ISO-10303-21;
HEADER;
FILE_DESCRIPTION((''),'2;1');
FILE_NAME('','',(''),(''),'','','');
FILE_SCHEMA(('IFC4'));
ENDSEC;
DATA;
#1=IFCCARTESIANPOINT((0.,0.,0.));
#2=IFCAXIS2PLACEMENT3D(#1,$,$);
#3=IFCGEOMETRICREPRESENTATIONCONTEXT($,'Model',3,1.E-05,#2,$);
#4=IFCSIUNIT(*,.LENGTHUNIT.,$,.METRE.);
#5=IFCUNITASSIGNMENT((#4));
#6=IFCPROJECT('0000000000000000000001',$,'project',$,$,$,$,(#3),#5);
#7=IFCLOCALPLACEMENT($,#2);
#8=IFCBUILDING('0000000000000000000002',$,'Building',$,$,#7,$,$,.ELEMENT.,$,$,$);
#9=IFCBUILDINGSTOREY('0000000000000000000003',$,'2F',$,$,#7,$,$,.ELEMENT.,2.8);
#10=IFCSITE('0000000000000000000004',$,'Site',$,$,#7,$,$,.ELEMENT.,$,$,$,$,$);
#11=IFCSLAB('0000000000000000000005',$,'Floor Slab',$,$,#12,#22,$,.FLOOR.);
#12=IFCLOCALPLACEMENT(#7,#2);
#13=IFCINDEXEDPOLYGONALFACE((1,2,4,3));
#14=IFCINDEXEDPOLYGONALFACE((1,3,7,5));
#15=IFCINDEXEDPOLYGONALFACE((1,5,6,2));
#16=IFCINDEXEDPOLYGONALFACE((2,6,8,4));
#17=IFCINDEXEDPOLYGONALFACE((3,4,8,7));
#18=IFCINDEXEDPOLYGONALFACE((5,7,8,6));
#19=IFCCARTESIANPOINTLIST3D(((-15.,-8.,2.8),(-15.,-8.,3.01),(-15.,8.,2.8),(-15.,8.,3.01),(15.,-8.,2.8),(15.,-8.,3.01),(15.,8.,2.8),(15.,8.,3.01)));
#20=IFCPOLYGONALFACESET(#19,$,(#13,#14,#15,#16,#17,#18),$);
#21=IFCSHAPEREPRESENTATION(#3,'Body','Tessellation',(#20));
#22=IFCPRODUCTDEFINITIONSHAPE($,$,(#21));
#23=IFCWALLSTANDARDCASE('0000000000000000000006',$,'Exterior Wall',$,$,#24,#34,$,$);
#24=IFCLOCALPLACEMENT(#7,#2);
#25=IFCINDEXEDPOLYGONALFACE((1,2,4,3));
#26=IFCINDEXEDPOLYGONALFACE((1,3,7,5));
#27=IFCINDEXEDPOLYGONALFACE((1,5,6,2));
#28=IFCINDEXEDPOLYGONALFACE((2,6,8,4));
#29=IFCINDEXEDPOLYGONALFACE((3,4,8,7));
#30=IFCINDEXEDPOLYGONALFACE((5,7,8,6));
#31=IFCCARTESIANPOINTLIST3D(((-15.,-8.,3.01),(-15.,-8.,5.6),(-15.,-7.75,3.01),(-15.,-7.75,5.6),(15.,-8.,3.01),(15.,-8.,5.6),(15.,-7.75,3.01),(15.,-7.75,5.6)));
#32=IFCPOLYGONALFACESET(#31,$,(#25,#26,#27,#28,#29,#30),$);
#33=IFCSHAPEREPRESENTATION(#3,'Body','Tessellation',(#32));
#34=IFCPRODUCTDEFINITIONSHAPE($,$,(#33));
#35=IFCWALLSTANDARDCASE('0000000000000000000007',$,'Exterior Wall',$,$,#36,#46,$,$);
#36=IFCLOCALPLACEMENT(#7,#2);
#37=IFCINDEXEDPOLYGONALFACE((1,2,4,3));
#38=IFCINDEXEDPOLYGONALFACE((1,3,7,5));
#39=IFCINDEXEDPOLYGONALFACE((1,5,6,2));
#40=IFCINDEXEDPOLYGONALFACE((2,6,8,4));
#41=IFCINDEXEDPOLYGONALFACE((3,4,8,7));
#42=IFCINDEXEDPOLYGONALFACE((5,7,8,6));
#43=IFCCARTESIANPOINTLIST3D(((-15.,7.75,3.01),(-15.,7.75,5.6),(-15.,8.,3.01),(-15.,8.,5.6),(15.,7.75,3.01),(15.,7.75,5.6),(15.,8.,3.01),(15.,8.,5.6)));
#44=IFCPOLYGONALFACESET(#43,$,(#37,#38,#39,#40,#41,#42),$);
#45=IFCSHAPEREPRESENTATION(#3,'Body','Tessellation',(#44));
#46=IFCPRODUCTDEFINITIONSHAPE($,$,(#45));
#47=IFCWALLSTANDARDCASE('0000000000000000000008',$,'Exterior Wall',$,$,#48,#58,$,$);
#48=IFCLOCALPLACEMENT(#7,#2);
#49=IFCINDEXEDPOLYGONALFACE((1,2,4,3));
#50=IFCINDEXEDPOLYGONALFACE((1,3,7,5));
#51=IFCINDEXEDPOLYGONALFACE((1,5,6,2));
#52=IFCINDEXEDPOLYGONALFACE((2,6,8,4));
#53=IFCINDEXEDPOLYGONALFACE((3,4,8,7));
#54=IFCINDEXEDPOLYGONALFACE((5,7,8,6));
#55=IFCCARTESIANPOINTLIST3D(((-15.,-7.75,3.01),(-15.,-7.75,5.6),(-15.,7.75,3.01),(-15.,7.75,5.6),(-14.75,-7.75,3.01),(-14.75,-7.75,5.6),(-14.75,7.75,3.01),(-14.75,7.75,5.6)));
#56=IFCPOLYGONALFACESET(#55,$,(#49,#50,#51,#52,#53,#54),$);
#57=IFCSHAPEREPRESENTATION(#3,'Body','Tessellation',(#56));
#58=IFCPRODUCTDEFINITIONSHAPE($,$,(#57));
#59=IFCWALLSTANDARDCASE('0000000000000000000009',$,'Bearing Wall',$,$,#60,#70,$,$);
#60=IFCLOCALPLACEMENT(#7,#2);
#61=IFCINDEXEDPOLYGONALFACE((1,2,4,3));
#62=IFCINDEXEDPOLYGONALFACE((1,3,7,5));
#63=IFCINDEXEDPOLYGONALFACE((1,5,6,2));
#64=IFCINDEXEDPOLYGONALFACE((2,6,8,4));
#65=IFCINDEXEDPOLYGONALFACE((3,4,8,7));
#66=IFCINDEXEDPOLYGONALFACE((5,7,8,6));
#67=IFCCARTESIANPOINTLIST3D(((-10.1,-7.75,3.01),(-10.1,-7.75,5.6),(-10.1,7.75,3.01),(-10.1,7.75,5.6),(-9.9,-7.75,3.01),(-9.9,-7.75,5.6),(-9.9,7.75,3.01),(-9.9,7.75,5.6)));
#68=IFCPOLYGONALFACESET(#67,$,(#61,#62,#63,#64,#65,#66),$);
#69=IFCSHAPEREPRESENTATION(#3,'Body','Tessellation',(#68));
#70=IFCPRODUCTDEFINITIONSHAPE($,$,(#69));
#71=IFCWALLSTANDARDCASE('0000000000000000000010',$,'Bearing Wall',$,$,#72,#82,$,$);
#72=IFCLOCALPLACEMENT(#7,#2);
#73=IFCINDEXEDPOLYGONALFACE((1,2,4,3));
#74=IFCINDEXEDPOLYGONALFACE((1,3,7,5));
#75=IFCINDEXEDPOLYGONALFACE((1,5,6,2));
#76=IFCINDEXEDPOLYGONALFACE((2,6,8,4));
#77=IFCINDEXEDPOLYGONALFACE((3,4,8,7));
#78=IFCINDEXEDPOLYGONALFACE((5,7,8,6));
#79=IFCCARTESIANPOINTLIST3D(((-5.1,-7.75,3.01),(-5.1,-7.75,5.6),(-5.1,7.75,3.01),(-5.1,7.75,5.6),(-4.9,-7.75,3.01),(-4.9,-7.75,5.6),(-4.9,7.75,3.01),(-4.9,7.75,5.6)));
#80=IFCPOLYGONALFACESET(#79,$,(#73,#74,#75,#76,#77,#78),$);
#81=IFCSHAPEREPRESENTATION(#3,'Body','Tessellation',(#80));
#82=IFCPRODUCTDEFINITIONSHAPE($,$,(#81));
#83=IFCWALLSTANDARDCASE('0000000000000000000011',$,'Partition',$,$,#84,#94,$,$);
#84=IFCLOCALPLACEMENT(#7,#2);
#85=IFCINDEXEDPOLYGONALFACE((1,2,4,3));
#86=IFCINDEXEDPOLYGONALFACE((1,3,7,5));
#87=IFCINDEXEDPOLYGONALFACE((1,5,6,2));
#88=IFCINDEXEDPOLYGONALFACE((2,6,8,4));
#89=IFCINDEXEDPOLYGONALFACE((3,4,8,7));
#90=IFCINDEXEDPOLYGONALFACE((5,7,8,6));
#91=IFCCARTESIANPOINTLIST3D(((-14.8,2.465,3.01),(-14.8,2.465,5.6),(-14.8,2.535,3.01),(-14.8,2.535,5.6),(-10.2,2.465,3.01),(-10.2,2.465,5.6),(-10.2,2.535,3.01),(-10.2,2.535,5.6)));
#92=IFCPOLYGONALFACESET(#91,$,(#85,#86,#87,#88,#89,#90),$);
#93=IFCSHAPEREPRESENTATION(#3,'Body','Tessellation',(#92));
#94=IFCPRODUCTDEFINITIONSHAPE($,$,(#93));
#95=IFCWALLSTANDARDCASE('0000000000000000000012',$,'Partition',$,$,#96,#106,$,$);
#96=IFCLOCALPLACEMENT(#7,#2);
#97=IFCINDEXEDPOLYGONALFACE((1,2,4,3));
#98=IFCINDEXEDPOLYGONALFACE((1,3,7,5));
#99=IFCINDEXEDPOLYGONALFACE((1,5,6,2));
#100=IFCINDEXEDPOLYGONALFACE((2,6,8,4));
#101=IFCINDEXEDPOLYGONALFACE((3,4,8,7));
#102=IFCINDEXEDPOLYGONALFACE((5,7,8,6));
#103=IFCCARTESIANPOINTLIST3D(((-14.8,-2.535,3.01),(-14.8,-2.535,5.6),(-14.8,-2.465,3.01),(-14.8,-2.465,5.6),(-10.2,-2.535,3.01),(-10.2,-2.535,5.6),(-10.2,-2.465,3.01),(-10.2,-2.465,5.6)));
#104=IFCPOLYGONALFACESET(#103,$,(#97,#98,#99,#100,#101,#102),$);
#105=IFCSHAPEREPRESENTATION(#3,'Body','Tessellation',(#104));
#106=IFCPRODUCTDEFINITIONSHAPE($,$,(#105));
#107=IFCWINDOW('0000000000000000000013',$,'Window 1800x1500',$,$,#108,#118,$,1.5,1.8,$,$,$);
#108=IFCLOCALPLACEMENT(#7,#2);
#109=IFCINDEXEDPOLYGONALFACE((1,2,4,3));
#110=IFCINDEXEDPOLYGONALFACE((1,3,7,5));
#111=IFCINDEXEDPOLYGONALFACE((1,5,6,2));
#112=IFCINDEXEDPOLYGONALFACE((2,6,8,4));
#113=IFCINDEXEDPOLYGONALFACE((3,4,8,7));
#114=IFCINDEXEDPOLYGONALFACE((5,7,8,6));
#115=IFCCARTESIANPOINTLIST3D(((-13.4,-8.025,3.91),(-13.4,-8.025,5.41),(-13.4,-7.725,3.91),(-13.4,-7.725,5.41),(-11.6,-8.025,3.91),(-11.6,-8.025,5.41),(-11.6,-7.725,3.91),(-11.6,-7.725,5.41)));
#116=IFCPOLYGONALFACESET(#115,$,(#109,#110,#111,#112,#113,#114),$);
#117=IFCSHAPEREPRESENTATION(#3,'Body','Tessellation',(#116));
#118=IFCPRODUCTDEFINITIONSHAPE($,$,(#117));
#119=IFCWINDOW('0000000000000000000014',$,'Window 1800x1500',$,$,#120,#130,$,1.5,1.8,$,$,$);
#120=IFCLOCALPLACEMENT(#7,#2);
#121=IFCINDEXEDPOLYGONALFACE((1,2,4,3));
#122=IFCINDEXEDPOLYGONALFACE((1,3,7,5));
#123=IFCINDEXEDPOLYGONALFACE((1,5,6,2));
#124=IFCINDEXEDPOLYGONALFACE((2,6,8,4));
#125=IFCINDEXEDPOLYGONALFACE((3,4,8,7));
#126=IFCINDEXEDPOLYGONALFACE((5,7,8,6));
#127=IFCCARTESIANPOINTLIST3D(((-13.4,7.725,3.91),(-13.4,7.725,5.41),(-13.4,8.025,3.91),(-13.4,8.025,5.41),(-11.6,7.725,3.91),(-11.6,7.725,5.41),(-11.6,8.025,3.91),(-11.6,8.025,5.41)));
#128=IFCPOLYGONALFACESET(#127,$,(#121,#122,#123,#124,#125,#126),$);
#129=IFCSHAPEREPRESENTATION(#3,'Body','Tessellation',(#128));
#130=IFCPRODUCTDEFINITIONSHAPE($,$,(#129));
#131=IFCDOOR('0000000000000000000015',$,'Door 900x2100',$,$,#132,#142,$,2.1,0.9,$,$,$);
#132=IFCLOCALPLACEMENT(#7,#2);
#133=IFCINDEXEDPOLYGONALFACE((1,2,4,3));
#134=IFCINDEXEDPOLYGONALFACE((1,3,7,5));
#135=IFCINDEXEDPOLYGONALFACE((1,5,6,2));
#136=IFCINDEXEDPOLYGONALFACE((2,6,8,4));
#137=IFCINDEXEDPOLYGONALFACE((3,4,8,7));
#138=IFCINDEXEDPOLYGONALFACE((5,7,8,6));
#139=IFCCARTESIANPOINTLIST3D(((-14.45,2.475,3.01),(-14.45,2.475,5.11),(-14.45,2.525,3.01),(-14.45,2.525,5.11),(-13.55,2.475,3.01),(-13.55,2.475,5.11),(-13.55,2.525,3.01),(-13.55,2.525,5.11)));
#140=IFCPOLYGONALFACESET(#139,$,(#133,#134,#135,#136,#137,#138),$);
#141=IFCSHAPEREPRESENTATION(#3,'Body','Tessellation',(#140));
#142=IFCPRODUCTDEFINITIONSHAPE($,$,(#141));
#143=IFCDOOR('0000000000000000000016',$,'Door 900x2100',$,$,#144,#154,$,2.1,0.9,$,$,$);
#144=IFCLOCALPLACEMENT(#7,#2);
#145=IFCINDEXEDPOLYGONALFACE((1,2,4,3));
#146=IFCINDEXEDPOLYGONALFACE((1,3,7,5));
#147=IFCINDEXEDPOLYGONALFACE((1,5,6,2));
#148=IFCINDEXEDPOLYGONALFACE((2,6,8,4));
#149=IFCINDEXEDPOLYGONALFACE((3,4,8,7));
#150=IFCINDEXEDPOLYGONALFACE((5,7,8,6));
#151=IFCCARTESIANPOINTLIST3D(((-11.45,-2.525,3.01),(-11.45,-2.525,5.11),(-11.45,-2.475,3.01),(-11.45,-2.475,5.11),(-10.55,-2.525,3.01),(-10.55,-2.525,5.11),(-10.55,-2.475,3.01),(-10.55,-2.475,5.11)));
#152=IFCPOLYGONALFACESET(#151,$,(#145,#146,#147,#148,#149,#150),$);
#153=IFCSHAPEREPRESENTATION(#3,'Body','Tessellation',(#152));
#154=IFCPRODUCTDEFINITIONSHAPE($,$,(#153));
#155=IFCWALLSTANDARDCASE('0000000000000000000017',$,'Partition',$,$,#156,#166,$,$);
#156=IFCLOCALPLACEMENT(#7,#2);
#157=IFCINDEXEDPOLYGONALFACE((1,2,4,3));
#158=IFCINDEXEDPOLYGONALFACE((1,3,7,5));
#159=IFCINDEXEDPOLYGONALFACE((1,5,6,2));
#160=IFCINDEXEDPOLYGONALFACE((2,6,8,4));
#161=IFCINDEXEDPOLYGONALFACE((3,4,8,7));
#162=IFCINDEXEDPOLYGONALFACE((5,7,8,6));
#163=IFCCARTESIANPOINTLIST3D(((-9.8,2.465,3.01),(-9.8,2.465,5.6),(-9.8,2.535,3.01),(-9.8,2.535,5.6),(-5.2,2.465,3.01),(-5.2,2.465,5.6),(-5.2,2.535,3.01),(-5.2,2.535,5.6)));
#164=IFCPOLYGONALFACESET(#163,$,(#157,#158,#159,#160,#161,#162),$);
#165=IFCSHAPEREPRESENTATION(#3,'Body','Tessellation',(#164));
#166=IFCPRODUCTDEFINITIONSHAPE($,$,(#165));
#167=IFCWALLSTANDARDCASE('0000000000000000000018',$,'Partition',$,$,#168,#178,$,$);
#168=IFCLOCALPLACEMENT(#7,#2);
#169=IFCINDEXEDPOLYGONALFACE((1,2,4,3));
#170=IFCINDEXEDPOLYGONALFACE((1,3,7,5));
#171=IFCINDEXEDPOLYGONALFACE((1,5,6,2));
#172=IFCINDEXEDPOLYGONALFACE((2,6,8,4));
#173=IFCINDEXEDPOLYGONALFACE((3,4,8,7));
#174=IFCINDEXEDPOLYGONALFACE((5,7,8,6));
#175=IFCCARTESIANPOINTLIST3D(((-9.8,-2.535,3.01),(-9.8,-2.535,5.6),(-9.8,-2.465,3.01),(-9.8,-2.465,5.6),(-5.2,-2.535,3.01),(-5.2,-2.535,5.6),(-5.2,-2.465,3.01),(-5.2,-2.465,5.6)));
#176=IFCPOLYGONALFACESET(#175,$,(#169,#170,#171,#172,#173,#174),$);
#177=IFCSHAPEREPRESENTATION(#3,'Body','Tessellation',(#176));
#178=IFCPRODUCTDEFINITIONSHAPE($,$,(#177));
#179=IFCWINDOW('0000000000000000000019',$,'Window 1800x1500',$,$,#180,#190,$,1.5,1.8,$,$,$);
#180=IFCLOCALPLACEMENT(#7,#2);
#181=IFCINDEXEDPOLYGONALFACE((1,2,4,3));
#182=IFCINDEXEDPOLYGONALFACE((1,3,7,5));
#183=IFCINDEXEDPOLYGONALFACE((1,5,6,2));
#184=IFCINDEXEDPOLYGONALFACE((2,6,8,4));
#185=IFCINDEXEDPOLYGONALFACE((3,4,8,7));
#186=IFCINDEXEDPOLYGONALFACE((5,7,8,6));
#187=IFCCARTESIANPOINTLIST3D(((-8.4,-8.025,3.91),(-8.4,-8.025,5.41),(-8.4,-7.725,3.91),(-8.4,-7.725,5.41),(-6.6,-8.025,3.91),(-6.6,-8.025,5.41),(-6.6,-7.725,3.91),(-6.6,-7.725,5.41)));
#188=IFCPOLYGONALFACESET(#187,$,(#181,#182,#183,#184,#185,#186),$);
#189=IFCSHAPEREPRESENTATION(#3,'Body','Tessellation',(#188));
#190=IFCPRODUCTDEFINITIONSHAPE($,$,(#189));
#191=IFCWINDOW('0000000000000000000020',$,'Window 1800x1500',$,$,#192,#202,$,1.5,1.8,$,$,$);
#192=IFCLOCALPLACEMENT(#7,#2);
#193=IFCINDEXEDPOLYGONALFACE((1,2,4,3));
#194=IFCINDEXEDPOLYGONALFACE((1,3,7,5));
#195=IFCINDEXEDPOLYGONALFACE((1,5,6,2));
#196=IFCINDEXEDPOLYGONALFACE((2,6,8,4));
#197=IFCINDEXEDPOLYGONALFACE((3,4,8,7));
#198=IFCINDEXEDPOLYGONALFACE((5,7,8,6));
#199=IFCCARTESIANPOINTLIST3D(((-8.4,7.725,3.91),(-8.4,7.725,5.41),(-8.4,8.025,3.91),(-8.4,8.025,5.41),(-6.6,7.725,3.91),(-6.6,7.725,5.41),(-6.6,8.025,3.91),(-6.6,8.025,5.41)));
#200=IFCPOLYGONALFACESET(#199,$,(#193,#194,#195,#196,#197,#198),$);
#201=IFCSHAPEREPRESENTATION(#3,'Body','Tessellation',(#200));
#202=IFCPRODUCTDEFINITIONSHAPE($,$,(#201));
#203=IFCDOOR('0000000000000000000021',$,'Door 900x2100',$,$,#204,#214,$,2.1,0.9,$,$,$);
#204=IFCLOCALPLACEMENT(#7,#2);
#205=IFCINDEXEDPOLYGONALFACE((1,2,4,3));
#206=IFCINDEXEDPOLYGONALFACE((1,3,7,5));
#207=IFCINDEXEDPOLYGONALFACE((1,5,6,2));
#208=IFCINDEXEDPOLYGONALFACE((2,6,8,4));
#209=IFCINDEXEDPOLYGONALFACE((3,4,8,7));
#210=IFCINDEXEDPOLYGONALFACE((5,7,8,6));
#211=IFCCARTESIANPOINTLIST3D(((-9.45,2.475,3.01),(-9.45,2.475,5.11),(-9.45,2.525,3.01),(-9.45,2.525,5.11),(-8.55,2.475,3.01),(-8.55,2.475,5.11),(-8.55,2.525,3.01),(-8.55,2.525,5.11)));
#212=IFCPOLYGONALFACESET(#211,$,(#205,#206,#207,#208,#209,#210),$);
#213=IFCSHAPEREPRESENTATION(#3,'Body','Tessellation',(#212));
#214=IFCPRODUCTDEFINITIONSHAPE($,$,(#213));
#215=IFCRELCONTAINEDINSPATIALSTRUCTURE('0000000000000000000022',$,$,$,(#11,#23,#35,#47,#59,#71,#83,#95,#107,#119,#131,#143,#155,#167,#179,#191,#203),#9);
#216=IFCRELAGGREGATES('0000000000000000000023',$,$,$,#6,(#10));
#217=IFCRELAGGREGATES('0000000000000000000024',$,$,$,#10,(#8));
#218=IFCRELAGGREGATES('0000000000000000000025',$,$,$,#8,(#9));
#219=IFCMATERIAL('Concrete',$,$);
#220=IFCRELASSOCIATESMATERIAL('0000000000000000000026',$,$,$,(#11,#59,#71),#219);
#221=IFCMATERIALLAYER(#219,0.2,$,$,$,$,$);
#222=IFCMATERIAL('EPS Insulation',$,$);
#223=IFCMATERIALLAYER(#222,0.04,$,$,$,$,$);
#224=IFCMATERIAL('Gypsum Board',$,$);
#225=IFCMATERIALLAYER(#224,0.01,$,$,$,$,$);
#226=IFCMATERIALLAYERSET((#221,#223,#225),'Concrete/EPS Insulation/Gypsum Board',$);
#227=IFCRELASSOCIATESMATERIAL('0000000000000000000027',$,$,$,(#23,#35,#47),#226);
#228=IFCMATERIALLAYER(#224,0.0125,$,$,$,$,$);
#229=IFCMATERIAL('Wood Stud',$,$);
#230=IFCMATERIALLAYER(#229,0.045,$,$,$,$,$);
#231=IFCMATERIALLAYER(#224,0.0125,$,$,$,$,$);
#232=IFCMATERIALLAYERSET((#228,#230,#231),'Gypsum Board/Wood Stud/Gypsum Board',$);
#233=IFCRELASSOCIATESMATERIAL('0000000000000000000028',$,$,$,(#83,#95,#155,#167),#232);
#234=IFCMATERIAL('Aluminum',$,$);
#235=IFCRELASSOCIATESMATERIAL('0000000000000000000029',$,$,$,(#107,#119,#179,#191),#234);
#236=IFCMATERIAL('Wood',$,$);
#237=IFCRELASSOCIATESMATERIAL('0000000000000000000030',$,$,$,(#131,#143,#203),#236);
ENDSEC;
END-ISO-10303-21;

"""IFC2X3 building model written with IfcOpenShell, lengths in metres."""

from ifc_helpers import new_model, si_unit, frame, origin, origin_2d, place, context, project, spatial, rectangle, extrude, material, layer, layer_set, layer_usage, element, save


model = new_model("IFC2X3")

# Units and contexts
model_context = context("Model", 3, precision=1e-05, world=origin())
ifc_project = project(units=[si_unit("LENGTHUNIT", "METRE")], contexts=[model_context])

# Site, building, storey
placement = place(None, origin())
site = spatial("IfcSite", under=ifc_project, at=placement, Name="Site", CompositionType="ELEMENT")
building = spatial("IfcBuilding", under=site, at=placement, Name="Building", CompositionType="ELEMENT")
storey = spatial("IfcBuildingStorey", under=building, at=placement, Name="2F", CompositionType="ELEMENT", Elevation=2.8)

# Slab
ifc_material_1 = material(Name="Concrete")
slab_placement = place(None, frame((0.0, 0.0, 2.8)))
element("IfcSlab", 1, at=slab_placement, inside=storey, material=ifc_material_1, Name="Floor Slab", PredefinedType="FLOOR", context=model_context, shape_type="SweptSolid", body=[
    extrude(rectangle(XDim=30.0, YDim=16.0, at=origin_2d()), origin(), (0.0, 0.0, 1.0), 0.21),
])

# Walls
ifc_layer_1 = layer(ifc_material_1, 0.2)
ifc_material_2 = material(Name="EPS Insulation")
ifc_layer_2 = layer(ifc_material_2, 0.04)
ifc_material_3 = material(Name="Gypsum Board")
ifc_layer_3 = layer(ifc_material_3, 0.01)
ifc_layer_set_1 = layer_set([ifc_layer_1, ifc_layer_2, ifc_layer_3], Name="Concrete/EPS Insulation/Gypsum Board")
ifc_layer_usage_1 = layer_usage(ifc_layer_set_1, "AXIS2", "POSITIVE", 0.0)
for number, where, name in (
    (2, (0.0, -7.875, 3.01), "Exterior Wall"),
    (3, (0.0, 7.875, 3.01), "Exterior Wall"),
):
    element("IfcWallStandardCase", number, at=place(None, frame(where)), inside=storey, material=ifc_layer_usage_1, Name=name, context=model_context, shape_type="SweptSolid", body=[
        extrude(rectangle(XDim=30.0, YDim=0.25, at=origin_2d()), origin(), (0.0, 0.0, 1.0), 2.59),
    ])
wall_placement = place(None, frame((-14.875, 0.0, 3.01)))
element("IfcWallStandardCase", 4, at=wall_placement, inside=storey, material=ifc_layer_usage_1, Name="Exterior Wall", context=model_context, shape_type="SweptSolid", body=[
    extrude(rectangle(XDim=0.25, YDim=15.5, at=origin_2d()), origin(), (0.0, 0.0, 1.0), 2.59),
])
for number, where, name in (
    (5, (-10.0, 0.0, 3.01), "Bearing Wall"),
    (6, (-5.0, 0.0, 3.01), "Bearing Wall"),
):
    element("IfcWallStandardCase", number, at=place(None, frame(where)), inside=storey, material=ifc_material_1, Name=name, context=model_context, shape_type="SweptSolid", body=[
        extrude(rectangle(XDim=0.2, YDim=15.5, at=origin_2d()), origin(), (0.0, 0.0, 1.0), 2.59),
    ])
ifc_layer_4 = layer(ifc_material_3, 0.0125)
ifc_material_4 = material(Name="Wood Stud")
ifc_layer_5 = layer(ifc_material_4, 0.045)
ifc_layer_6 = layer(ifc_material_3, 0.0125)
ifc_layer_set_2 = layer_set([ifc_layer_4, ifc_layer_5, ifc_layer_6], Name="Gypsum Board/Wood Stud/Gypsum Board")
ifc_layer_usage_2 = layer_usage(ifc_layer_set_2, "AXIS2", "POSITIVE", 0.0)
for number, where, name in (
    (7, (-12.5, 2.5, 3.01), "Partition"),
    (8, (-12.5, -2.5, 3.01), "Partition"),
):
    element("IfcWallStandardCase", number, at=place(None, frame(where)), inside=storey, material=ifc_layer_usage_2, Name=name, context=model_context, shape_type="SweptSolid", body=[
        extrude(rectangle(XDim=4.6, YDim=0.07, at=origin_2d()), origin(), (0.0, 0.0, 1.0), 2.59),
    ])

# Windows
ifc_material_5 = material(Name="Aluminum")
for number, where, name in (
    (9, (-12.5, -7.875, 3.91), "Window 1800x1500"),
    (10, (-12.5, 7.875, 3.91), "Window 1800x1500"),
):
    element("IfcWindow", number, at=place(None, frame(where)), inside=storey, material=ifc_material_5, Name=name, OverallHeight=1.5, OverallWidth=1.8, context=model_context, shape_type="SweptSolid", body=[
        extrude(rectangle(XDim=1.8, YDim=0.3, at=origin_2d()), origin(), (0.0, 0.0, 1.0), 1.5),
    ])

# Doors
ifc_material_6 = material(Name="Wood")
for number, where, name in (
    (11, (-14.0, 2.5, 3.01), "Door 900x2100"),
    (12, (-11.0, -2.5, 3.01), "Door 900x2100"),
):
    element("IfcDoor", number, at=place(None, frame(where)), inside=storey, material=ifc_material_6, Name=name, OverallHeight=2.1, OverallWidth=0.9, context=model_context, shape_type="SweptSolid", body=[
        extrude(rectangle(XDim=0.9, YDim=0.05, at=origin_2d()), origin(), (0.0, 0.0, 1.0), 2.1),
    ])

# Walls
for number, where, name in (
    (13, (-7.5, 2.5, 3.01), "Partition"),
    (14, (-7.5, -2.5, 3.01), "Partition"),
):
    element("IfcWallStandardCase", number, at=place(None, frame(where)), inside=storey, material=ifc_layer_usage_2, Name=name, context=model_context, shape_type="SweptSolid", body=[
        extrude(rectangle(XDim=4.6, YDim=0.07, at=origin_2d()), origin(), (0.0, 0.0, 1.0), 2.59),
    ])

# Windows
for number, where, name in (
    (15, (-7.5, -7.875, 3.91), "Window 1800x1500"),
    (16, (-7.5, 7.875, 3.91), "Window 1800x1500"),
):
    element("IfcWindow", number, at=place(None, frame(where)), inside=storey, material=ifc_material_5, Name=name, OverallHeight=1.5, OverallWidth=1.8, context=model_context, shape_type="SweptSolid", body=[
        extrude(rectangle(XDim=1.8, YDim=0.3, at=origin_2d()), origin(), (0.0, 0.0, 1.0), 1.5),
    ])

# Door
for number, where, name in (
    (17, (-9.0, 2.5, 3.01), "Door 900x2100"),
):
    element("IfcDoor", number, at=place(None, frame(where)), inside=storey, material=ifc_material_6, Name=name, OverallHeight=2.1, OverallWidth=0.9, context=model_context, shape_type="SweptSolid", body=[
        extrude(rectangle(XDim=0.9, YDim=0.05, at=origin_2d()), origin(), (0.0, 0.0, 1.0), 2.1),
    ])

save(model, "model.ifc")
